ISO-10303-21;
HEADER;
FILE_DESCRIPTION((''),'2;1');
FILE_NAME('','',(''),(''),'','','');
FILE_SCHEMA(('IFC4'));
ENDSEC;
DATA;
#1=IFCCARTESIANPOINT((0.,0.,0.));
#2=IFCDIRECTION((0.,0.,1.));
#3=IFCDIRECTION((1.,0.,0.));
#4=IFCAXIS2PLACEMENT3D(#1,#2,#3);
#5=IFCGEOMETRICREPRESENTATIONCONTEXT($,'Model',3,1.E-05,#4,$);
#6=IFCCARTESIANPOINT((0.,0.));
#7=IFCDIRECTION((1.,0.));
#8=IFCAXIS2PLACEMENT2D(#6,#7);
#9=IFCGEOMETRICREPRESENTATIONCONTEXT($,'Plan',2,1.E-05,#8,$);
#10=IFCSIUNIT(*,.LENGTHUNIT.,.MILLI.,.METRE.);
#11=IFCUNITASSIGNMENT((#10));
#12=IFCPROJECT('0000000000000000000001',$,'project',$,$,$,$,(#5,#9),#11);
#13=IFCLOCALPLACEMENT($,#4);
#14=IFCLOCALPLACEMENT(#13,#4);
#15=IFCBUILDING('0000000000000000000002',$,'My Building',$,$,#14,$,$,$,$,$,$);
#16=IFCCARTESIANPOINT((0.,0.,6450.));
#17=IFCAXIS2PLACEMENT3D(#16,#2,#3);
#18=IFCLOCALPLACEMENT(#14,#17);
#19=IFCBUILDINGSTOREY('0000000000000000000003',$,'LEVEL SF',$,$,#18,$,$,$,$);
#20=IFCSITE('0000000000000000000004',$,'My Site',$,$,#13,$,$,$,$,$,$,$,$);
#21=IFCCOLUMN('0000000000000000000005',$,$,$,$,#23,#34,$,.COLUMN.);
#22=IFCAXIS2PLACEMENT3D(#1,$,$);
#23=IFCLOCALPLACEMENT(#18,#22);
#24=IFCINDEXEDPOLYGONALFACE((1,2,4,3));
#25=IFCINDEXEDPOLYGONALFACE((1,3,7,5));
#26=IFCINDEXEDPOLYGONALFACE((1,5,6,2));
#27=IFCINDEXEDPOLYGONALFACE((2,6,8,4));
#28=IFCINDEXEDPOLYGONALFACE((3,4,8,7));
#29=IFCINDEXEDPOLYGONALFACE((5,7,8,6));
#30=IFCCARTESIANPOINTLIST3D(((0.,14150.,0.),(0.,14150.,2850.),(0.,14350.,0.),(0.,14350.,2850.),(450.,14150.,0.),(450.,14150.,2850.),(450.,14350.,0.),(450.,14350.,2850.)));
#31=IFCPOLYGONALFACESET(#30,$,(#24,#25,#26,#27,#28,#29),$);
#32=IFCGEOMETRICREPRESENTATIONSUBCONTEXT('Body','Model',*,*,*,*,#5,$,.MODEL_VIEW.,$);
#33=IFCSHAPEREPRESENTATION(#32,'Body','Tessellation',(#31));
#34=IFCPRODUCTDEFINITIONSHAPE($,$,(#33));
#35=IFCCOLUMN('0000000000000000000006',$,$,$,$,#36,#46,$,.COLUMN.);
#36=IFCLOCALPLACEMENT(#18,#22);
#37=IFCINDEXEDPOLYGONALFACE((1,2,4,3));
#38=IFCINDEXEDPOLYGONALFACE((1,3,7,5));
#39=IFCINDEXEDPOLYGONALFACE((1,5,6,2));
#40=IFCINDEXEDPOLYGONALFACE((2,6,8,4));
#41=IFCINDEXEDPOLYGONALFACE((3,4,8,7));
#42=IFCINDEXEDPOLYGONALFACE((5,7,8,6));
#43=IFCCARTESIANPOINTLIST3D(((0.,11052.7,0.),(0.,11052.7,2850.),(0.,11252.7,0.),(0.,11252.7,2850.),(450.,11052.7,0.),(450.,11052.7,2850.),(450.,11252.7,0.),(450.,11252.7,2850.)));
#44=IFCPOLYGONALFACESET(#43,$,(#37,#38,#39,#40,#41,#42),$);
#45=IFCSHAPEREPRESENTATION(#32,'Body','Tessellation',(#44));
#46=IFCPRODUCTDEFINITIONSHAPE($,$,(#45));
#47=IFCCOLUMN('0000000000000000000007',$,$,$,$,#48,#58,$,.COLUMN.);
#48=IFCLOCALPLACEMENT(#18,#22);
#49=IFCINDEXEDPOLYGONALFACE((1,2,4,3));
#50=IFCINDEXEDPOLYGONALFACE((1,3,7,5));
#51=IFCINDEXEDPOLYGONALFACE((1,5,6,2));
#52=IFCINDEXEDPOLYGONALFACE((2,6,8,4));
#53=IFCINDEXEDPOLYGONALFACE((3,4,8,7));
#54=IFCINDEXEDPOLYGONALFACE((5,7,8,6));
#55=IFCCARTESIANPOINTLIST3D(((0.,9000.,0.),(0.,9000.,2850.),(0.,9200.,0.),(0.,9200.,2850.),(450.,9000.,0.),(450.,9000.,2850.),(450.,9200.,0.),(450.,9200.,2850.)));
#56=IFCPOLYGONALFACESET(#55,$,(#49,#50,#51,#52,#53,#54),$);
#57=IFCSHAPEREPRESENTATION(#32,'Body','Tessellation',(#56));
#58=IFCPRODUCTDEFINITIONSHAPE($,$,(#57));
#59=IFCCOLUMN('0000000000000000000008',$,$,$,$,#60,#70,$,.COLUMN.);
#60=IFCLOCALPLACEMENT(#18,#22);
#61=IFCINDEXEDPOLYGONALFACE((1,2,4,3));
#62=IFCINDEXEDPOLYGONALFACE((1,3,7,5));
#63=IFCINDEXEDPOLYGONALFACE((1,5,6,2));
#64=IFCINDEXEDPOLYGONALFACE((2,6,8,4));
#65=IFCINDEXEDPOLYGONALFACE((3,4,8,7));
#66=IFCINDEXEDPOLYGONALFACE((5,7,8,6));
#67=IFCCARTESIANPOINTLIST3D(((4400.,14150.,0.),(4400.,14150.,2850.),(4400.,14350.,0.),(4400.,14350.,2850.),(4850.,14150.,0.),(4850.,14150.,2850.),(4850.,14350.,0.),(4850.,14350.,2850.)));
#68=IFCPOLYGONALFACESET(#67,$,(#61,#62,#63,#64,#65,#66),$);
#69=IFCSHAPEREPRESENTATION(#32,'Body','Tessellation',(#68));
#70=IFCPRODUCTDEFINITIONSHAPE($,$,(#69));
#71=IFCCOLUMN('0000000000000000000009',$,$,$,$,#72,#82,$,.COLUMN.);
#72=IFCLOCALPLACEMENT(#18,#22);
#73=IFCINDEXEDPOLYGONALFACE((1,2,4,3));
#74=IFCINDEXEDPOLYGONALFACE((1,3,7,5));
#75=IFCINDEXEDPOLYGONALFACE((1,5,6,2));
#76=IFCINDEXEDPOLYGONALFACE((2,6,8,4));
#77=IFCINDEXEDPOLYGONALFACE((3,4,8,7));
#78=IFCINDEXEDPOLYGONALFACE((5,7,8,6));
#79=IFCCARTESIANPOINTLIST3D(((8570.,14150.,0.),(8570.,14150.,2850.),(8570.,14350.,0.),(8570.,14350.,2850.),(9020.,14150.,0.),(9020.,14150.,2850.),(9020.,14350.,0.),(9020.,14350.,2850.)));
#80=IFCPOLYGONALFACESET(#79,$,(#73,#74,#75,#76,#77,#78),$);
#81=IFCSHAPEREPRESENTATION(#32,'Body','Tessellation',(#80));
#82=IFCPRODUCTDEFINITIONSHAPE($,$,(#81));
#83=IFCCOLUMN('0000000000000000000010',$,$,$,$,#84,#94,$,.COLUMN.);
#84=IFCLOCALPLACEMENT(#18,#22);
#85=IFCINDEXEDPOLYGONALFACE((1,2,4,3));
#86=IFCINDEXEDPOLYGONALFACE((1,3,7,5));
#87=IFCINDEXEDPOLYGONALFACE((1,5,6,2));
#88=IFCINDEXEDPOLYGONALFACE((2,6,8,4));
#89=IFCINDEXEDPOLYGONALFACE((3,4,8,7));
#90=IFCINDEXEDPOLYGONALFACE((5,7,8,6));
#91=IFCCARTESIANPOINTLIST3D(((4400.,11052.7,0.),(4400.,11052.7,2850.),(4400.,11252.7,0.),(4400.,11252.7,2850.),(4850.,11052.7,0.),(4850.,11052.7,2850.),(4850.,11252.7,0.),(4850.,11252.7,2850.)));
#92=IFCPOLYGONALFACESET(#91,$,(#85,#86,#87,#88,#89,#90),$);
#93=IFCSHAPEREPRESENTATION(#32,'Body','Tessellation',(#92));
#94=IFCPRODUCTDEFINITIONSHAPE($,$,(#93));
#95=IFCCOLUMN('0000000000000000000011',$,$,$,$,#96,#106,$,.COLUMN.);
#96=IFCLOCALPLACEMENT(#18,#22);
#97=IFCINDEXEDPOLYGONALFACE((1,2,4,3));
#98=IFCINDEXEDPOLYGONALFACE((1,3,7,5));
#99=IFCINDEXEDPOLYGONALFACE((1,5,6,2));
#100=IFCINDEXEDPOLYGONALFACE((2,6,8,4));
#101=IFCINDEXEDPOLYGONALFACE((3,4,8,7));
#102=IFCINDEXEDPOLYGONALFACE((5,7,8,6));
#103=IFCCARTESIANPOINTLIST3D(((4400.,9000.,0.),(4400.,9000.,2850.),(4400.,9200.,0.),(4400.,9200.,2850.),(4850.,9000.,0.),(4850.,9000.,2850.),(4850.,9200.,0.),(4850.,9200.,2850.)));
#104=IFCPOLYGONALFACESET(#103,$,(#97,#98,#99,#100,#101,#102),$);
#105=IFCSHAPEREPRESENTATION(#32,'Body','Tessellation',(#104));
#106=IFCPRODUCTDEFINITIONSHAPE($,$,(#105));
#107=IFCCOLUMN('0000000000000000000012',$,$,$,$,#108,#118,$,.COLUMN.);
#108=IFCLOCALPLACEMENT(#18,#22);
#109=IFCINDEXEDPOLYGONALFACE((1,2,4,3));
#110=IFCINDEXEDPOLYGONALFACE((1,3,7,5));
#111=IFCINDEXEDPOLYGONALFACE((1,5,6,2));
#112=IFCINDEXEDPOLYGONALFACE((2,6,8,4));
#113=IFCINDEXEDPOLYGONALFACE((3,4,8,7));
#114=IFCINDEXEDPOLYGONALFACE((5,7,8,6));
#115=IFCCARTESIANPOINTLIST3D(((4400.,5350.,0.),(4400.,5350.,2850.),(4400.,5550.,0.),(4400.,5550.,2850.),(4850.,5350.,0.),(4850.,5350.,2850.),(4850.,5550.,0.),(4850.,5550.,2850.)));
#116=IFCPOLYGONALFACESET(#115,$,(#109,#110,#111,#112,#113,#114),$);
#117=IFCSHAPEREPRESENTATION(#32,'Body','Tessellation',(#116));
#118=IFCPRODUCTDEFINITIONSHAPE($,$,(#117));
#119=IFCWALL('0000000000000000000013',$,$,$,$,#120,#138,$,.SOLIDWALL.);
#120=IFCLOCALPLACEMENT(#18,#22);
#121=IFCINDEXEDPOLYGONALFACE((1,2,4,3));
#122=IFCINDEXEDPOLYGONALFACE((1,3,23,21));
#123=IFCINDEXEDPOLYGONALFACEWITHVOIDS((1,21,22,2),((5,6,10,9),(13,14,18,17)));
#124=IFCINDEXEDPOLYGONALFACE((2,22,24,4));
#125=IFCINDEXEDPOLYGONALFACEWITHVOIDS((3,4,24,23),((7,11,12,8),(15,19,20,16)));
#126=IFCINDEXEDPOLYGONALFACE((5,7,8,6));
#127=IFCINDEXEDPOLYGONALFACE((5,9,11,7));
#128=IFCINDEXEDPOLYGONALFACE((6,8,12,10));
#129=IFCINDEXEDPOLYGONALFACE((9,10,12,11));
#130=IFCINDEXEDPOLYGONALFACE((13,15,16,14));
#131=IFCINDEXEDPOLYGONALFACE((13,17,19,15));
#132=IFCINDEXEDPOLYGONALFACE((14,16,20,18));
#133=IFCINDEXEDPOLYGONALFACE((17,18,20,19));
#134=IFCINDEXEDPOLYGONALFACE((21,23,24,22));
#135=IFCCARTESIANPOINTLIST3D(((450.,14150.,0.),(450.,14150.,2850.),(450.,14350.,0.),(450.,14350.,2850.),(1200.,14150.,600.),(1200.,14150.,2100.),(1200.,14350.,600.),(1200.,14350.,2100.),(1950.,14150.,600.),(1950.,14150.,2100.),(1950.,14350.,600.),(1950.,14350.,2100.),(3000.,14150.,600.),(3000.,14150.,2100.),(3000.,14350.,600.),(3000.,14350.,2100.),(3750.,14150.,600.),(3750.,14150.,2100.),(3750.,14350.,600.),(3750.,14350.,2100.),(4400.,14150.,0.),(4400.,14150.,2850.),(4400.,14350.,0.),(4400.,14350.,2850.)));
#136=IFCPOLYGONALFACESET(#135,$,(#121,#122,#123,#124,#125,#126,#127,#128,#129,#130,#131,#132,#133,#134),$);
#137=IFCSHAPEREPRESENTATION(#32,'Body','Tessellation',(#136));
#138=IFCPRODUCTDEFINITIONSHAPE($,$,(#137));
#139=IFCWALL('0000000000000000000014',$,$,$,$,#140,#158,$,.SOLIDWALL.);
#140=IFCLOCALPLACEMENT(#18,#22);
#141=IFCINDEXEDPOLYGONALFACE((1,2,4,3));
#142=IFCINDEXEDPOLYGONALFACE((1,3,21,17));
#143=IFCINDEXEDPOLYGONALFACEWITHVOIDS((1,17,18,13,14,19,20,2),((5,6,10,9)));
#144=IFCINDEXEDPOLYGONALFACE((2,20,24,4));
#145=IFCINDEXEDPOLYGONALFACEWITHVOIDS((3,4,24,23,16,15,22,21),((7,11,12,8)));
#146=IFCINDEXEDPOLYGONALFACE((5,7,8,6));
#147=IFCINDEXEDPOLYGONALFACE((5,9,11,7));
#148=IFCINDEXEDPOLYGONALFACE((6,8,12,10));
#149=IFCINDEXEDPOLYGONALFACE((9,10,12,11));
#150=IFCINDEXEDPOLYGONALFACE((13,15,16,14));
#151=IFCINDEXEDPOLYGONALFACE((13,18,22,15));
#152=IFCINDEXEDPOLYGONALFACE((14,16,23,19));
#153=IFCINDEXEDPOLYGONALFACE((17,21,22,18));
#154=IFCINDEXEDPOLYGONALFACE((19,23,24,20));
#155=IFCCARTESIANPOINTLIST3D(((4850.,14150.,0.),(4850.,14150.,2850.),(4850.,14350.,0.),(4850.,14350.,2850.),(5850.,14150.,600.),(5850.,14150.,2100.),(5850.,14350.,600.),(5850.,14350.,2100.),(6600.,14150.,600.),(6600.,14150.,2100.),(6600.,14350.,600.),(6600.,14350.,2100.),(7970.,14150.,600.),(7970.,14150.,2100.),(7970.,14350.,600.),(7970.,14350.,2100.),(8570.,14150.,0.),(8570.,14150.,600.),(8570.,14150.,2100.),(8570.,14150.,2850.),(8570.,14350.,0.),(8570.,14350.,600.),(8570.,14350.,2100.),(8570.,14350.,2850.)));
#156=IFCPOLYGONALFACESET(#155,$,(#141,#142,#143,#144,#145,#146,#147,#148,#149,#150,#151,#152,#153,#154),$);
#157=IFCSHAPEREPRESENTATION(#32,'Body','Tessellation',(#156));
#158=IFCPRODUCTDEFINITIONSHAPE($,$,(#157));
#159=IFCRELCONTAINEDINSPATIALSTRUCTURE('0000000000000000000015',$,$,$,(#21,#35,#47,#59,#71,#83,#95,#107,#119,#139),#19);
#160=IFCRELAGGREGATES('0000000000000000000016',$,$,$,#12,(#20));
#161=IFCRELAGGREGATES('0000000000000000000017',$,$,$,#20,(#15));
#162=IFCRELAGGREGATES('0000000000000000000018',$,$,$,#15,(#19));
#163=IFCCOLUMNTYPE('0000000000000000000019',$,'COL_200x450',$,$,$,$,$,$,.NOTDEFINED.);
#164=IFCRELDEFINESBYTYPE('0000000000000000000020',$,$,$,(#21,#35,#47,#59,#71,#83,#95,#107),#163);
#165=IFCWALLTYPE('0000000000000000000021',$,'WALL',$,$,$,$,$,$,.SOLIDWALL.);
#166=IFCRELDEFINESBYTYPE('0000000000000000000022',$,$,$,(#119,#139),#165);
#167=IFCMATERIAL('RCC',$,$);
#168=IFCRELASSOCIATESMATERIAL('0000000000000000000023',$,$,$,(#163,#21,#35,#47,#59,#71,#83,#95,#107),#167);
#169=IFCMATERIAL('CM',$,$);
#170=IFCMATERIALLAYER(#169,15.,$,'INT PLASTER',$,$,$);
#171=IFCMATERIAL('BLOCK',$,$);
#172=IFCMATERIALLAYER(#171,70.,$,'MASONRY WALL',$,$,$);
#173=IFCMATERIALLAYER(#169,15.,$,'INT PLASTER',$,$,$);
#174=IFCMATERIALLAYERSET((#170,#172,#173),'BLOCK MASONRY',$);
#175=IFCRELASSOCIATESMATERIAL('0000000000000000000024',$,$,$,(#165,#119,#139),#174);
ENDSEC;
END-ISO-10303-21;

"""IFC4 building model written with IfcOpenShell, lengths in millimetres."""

from ifc_helpers import new_model, si_unit, frame, origin_with_axes, origin_2d_with_axis, place, context, subcontext, project, spatial, indexed_curve, rectangle, outline, extrude, material, layer, layer_set, layer_usage, material_profile, profile_set, profile_usage, type_object, element, save


model = new_model("IFC4")

# Units and contexts
model_context = context("Model", 3, precision=1e-05, world=origin_with_axes())
plan_context = context("Plan", 2, precision=1e-05, world=origin_2d_with_axis())
body_context = subcontext(model_context, "Body", "Model", "MODEL_VIEW")
ifc_project = project(units=[si_unit("LENGTHUNIT", "METRE", prefix="MILLI")], contexts=[model_context, plan_context])

# Site, building, storey
site_placement = place(None, origin_with_axes())
site = spatial("IfcSite", under=ifc_project, at=site_placement, Name="My Site")
building_placement = place(site_placement, origin_with_axes())
building = spatial("IfcBuilding", under=site, at=building_placement, Name="My Building")
storey_placement = place(building_placement, frame((0.0, 0.0, 6450.0), z_axis=(0.0, 0.0, 1.0), x_axis=(1.0, 0.0, 0.0)))
storey = spatial("IfcBuildingStorey", under=building, at=storey_placement, Name="LEVEL SF")

# Columns
ifc_material_1 = material(Name="RCC")
ifc_material_profile = material_profile(ifc_material_1, rectangle(XDim=200.0, YDim=450.0))
ifc_profile_set = profile_set([ifc_material_profile], Name="COL_200x450")
ifc_profile_usage_1 = profile_usage(ifc_profile_set)
column_type = type_object("IfcColumnType", Name="COL_200x450", PredefinedType="NOTDEFINED", material=ifc_profile_set)
column_1_placement = place(storey_placement, frame((225.0, 14250.0, 0.0), z_axis=(0.0, 0.0, 1.0), x_axis=(0.0, -1.0, 0.0)))
element("IfcColumn", 1, at=column_1_placement, inside=storey, type_object=column_type, material=ifc_profile_usage_1, PredefinedType="COLUMN", context=body_context, shape_type="SweptSolid", body=[
    extrude(rectangle(XDim=200.0, YDim=450.0), origin_with_axes(), (0.0, 0.0, 1.0), 2850.0),
])
ifc_profile_usage_2 = profile_usage(ifc_profile_set)
column_2_placement = place(storey_placement, frame((225.0, 11152.7, 0.0), z_axis=(0.0, 0.0, 1.0), x_axis=(0.0, -1.0, 0.0)))
element("IfcColumn", 2, at=column_2_placement, inside=storey, type_object=column_type, material=ifc_profile_usage_2, PredefinedType="COLUMN", context=body_context, shape_type="SweptSolid", body=[
    extrude(rectangle(XDim=200.0, YDim=450.0), origin_with_axes(), (0.0, 0.0, 1.0), 2850.0),
])
ifc_profile_usage_3 = profile_usage(ifc_profile_set)
column_3_placement = place(storey_placement, frame((225.0, 9100.0, 0.0), z_axis=(0.0, 0.0, 1.0), x_axis=(0.0, -1.0, 0.0)))
element("IfcColumn", 3, at=column_3_placement, inside=storey, type_object=column_type, material=ifc_profile_usage_3, PredefinedType="COLUMN", context=body_context, shape_type="SweptSolid", body=[
    extrude(rectangle(XDim=200.0, YDim=450.0), origin_with_axes(), (0.0, 0.0, 1.0), 2850.0),
])
ifc_profile_usage_4 = profile_usage(ifc_profile_set)
column_4_placement = place(storey_placement, frame((4625.0, 14250.0, 0.0), z_axis=(0.0, 0.0, 1.0), x_axis=(0.0, -1.0, 0.0)))
element("IfcColumn", 4, at=column_4_placement, inside=storey, type_object=column_type, material=ifc_profile_usage_4, PredefinedType="COLUMN", context=body_context, shape_type="SweptSolid", body=[
    extrude(rectangle(XDim=200.0, YDim=450.0), origin_with_axes(), (0.0, 0.0, 1.0), 2850.0),
])
ifc_profile_usage_5 = profile_usage(ifc_profile_set)
column_5_placement = place(storey_placement, frame((8795.0, 14250.0, 0.0), z_axis=(0.0, 0.0, 1.0), x_axis=(0.0, -1.0, 0.0)))
element("IfcColumn", 5, at=column_5_placement, inside=storey, type_object=column_type, material=ifc_profile_usage_5, PredefinedType="COLUMN", context=body_context, shape_type="SweptSolid", body=[
    extrude(rectangle(XDim=200.0, YDim=450.0), origin_with_axes(), (0.0, 0.0, 1.0), 2850.0),
])
ifc_profile_usage_6 = profile_usage(ifc_profile_set)
column_6_placement = place(storey_placement, frame((4625.0, 11152.7, 0.0), z_axis=(0.0, 0.0, 1.0), x_axis=(0.0, -1.0, 0.0)))
element("IfcColumn", 6, at=column_6_placement, inside=storey, type_object=column_type, material=ifc_profile_usage_6, PredefinedType="COLUMN", context=body_context, shape_type="SweptSolid", body=[
    extrude(rectangle(XDim=200.0, YDim=450.0), origin_with_axes(), (0.0, 0.0, 1.0), 2850.0),
])
ifc_profile_usage_7 = profile_usage(ifc_profile_set)
column_7_placement = place(storey_placement, frame((4625.0, 9100.0, 0.0), z_axis=(0.0, 0.0, 1.0), x_axis=(0.0, -1.0, 0.0)))
element("IfcColumn", 7, at=column_7_placement, inside=storey, type_object=column_type, material=ifc_profile_usage_7, PredefinedType="COLUMN", context=body_context, shape_type="SweptSolid", body=[
    extrude(rectangle(XDim=200.0, YDim=450.0), origin_with_axes(), (0.0, 0.0, 1.0), 2850.0),
])
ifc_profile_usage_8 = profile_usage(ifc_profile_set)
column_8_placement = place(storey_placement, frame((4625.0, 5450.0, 0.0), z_axis=(0.0, 0.0, 1.0), x_axis=(0.0, -1.0, 0.0)))
element("IfcColumn", 8, at=column_8_placement, inside=storey, type_object=column_type, material=ifc_profile_usage_8, PredefinedType="COLUMN", context=body_context, shape_type="SweptSolid", body=[
    extrude(rectangle(XDim=200.0, YDim=450.0), origin_with_axes(), (0.0, 0.0, 1.0), 2850.0),
])

# Walls, openings
ifc_material_2 = material(Name="CM")
ifc_layer_1 = layer(ifc_material_2, 15.0, Name="INT PLASTER")
ifc_material_3 = material(Name="BLOCK")
ifc_layer_2 = layer(ifc_material_3, 70.0, Name="MASONRY WALL")
ifc_layer_3 = layer(ifc_material_2, 15.0, Name="INT PLASTER")
ifc_layer_set = layer_set([ifc_layer_1, ifc_layer_2, ifc_layer_3], Name="BLOCK MASONRY")
ifc_layer_usage_1 = layer_usage(ifc_layer_set, "AXIS2", "POSITIVE", 0.0)
wall_type = type_object("IfcWallType", Name="WALL", PredefinedType="SOLIDWALL", material=ifc_layer_set)
wall_1_placement = place(storey_placement, frame((450.0, 14350.0, 0.0), z_axis=(0.0, 0.0, 1.0), x_axis=(0.0, -1.0, 0.0)))
wall_1 = element("IfcWall", 9, at=wall_1_placement, inside=storey, type_object=wall_type, material=ifc_layer_usage_1, PredefinedType="SOLIDWALL", context=body_context, shape_type="SweptSolid", body=[
    extrude(outline(indexed_curve([(0.0, 0.0), (0.0, 3950.0), (200.0, 3950.0), (200.0, 0.0), (0.0, 0.0)], self_intersect=False)), origin_with_axes(), (0.0, 0.0, 1.0), 2850.0),
])
opening_1_placement = place(wall_1_placement, frame((200.0, 2550.0, 600.0), z_axis=(0.0, 0.0, 1.0), x_axis=(0.0, 1.0, 0.0)))
element("IfcOpeningElement", 10, at=opening_1_placement, cuts=wall_1, PredefinedType="OPENING", context=body_context, shape_type="SweptSolid", body=[
    extrude(outline(indexed_curve([(0.0, 0.0), (0.0, 400.0), (750.0, 400.0), (750.0, 0.0), (0.0, 0.0)], self_intersect=False)), frame((0.0, -100.0, 0.0), z_axis=(0.0, 0.0, 1.0), x_axis=(1.0, 0.0, 0.0)), (0.0, 0.0, 1.0), 1500.0),
])
opening_2_placement = place(wall_1_placement, frame((200.0, 750.0, 600.0), z_axis=(0.0, 0.0, 1.0), x_axis=(0.0, 1.0, 0.0)))
element("IfcOpeningElement", 11, at=opening_2_placement, cuts=wall_1, PredefinedType="OPENING", context=body_context, shape_type="SweptSolid", body=[
    extrude(outline(indexed_curve([(0.0, 0.0), (0.0, 400.0), (750.0, 400.0), (750.0, 0.0), (0.0, 0.0)], self_intersect=False)), frame((0.0, -100.0, 0.0), z_axis=(0.0, 0.0, 1.0), x_axis=(1.0, 0.0, 0.0)), (0.0, 0.0, 1.0), 1500.0),
])
ifc_layer_usage_2 = layer_usage(ifc_layer_set, "AXIS2", "POSITIVE", 0.0)
wall_2_placement = place(storey_placement, frame((4850.0, 14350.0, 0.0), z_axis=(0.0, 0.0, 1.0), x_axis=(0.0, -1.0, 0.0)))
wall_2 = element("IfcWall", 12, at=wall_2_placement, inside=storey, type_object=wall_type, material=ifc_layer_usage_2, PredefinedType="SOLIDWALL", context=body_context, shape_type="SweptSolid", body=[
    extrude(outline(indexed_curve([(0.0, 0.0), (0.0, 3720.0), (200.0, 3720.0), (200.0, 0.0), (0.0, 0.0)], self_intersect=False)), origin_with_axes(), (0.0, 0.0, 1.0), 2850.0),
])
opening_3_placement = place(wall_2_placement, frame((200.0, 1000.0, 600.0), z_axis=(0.0, 0.0, 1.0), x_axis=(0.0, 1.0, 0.0)))
element("IfcOpeningElement", 13, at=opening_3_placement, cuts=wall_2, PredefinedType="OPENING", context=body_context, shape_type="SweptSolid", body=[
    extrude(outline(indexed_curve([(0.0, 0.0), (0.0, 400.0), (750.0, 400.0), (750.0, 0.0), (0.0, 0.0)], self_intersect=False)), frame((0.0, -100.0, 0.0), z_axis=(0.0, 0.0, 1.0), x_axis=(1.0, 0.0, 0.0)), (0.0, 0.0, 1.0), 1500.0),
])
opening_4_placement = place(wall_2_placement, frame((200.0, 3120.0, 600.0), z_axis=(0.0, 0.0, 1.0), x_axis=(0.0, 1.0, 0.0)))
element("IfcOpeningElement", 14, at=opening_4_placement, cuts=wall_2, PredefinedType="OPENING", context=body_context, shape_type="SweptSolid", body=[
    extrude(outline(indexed_curve([(0.0, 0.0), (0.0, 400.0), (750.0, 400.0), (750.0, 0.0), (0.0, 0.0)], self_intersect=False)), frame((0.0, -100.0, 0.0), z_axis=(0.0, 0.0, 1.0), x_axis=(1.0, 0.0, 0.0)), (0.0, 0.0, 1.0), 1500.0),
])

save(model, "model.ifc")
